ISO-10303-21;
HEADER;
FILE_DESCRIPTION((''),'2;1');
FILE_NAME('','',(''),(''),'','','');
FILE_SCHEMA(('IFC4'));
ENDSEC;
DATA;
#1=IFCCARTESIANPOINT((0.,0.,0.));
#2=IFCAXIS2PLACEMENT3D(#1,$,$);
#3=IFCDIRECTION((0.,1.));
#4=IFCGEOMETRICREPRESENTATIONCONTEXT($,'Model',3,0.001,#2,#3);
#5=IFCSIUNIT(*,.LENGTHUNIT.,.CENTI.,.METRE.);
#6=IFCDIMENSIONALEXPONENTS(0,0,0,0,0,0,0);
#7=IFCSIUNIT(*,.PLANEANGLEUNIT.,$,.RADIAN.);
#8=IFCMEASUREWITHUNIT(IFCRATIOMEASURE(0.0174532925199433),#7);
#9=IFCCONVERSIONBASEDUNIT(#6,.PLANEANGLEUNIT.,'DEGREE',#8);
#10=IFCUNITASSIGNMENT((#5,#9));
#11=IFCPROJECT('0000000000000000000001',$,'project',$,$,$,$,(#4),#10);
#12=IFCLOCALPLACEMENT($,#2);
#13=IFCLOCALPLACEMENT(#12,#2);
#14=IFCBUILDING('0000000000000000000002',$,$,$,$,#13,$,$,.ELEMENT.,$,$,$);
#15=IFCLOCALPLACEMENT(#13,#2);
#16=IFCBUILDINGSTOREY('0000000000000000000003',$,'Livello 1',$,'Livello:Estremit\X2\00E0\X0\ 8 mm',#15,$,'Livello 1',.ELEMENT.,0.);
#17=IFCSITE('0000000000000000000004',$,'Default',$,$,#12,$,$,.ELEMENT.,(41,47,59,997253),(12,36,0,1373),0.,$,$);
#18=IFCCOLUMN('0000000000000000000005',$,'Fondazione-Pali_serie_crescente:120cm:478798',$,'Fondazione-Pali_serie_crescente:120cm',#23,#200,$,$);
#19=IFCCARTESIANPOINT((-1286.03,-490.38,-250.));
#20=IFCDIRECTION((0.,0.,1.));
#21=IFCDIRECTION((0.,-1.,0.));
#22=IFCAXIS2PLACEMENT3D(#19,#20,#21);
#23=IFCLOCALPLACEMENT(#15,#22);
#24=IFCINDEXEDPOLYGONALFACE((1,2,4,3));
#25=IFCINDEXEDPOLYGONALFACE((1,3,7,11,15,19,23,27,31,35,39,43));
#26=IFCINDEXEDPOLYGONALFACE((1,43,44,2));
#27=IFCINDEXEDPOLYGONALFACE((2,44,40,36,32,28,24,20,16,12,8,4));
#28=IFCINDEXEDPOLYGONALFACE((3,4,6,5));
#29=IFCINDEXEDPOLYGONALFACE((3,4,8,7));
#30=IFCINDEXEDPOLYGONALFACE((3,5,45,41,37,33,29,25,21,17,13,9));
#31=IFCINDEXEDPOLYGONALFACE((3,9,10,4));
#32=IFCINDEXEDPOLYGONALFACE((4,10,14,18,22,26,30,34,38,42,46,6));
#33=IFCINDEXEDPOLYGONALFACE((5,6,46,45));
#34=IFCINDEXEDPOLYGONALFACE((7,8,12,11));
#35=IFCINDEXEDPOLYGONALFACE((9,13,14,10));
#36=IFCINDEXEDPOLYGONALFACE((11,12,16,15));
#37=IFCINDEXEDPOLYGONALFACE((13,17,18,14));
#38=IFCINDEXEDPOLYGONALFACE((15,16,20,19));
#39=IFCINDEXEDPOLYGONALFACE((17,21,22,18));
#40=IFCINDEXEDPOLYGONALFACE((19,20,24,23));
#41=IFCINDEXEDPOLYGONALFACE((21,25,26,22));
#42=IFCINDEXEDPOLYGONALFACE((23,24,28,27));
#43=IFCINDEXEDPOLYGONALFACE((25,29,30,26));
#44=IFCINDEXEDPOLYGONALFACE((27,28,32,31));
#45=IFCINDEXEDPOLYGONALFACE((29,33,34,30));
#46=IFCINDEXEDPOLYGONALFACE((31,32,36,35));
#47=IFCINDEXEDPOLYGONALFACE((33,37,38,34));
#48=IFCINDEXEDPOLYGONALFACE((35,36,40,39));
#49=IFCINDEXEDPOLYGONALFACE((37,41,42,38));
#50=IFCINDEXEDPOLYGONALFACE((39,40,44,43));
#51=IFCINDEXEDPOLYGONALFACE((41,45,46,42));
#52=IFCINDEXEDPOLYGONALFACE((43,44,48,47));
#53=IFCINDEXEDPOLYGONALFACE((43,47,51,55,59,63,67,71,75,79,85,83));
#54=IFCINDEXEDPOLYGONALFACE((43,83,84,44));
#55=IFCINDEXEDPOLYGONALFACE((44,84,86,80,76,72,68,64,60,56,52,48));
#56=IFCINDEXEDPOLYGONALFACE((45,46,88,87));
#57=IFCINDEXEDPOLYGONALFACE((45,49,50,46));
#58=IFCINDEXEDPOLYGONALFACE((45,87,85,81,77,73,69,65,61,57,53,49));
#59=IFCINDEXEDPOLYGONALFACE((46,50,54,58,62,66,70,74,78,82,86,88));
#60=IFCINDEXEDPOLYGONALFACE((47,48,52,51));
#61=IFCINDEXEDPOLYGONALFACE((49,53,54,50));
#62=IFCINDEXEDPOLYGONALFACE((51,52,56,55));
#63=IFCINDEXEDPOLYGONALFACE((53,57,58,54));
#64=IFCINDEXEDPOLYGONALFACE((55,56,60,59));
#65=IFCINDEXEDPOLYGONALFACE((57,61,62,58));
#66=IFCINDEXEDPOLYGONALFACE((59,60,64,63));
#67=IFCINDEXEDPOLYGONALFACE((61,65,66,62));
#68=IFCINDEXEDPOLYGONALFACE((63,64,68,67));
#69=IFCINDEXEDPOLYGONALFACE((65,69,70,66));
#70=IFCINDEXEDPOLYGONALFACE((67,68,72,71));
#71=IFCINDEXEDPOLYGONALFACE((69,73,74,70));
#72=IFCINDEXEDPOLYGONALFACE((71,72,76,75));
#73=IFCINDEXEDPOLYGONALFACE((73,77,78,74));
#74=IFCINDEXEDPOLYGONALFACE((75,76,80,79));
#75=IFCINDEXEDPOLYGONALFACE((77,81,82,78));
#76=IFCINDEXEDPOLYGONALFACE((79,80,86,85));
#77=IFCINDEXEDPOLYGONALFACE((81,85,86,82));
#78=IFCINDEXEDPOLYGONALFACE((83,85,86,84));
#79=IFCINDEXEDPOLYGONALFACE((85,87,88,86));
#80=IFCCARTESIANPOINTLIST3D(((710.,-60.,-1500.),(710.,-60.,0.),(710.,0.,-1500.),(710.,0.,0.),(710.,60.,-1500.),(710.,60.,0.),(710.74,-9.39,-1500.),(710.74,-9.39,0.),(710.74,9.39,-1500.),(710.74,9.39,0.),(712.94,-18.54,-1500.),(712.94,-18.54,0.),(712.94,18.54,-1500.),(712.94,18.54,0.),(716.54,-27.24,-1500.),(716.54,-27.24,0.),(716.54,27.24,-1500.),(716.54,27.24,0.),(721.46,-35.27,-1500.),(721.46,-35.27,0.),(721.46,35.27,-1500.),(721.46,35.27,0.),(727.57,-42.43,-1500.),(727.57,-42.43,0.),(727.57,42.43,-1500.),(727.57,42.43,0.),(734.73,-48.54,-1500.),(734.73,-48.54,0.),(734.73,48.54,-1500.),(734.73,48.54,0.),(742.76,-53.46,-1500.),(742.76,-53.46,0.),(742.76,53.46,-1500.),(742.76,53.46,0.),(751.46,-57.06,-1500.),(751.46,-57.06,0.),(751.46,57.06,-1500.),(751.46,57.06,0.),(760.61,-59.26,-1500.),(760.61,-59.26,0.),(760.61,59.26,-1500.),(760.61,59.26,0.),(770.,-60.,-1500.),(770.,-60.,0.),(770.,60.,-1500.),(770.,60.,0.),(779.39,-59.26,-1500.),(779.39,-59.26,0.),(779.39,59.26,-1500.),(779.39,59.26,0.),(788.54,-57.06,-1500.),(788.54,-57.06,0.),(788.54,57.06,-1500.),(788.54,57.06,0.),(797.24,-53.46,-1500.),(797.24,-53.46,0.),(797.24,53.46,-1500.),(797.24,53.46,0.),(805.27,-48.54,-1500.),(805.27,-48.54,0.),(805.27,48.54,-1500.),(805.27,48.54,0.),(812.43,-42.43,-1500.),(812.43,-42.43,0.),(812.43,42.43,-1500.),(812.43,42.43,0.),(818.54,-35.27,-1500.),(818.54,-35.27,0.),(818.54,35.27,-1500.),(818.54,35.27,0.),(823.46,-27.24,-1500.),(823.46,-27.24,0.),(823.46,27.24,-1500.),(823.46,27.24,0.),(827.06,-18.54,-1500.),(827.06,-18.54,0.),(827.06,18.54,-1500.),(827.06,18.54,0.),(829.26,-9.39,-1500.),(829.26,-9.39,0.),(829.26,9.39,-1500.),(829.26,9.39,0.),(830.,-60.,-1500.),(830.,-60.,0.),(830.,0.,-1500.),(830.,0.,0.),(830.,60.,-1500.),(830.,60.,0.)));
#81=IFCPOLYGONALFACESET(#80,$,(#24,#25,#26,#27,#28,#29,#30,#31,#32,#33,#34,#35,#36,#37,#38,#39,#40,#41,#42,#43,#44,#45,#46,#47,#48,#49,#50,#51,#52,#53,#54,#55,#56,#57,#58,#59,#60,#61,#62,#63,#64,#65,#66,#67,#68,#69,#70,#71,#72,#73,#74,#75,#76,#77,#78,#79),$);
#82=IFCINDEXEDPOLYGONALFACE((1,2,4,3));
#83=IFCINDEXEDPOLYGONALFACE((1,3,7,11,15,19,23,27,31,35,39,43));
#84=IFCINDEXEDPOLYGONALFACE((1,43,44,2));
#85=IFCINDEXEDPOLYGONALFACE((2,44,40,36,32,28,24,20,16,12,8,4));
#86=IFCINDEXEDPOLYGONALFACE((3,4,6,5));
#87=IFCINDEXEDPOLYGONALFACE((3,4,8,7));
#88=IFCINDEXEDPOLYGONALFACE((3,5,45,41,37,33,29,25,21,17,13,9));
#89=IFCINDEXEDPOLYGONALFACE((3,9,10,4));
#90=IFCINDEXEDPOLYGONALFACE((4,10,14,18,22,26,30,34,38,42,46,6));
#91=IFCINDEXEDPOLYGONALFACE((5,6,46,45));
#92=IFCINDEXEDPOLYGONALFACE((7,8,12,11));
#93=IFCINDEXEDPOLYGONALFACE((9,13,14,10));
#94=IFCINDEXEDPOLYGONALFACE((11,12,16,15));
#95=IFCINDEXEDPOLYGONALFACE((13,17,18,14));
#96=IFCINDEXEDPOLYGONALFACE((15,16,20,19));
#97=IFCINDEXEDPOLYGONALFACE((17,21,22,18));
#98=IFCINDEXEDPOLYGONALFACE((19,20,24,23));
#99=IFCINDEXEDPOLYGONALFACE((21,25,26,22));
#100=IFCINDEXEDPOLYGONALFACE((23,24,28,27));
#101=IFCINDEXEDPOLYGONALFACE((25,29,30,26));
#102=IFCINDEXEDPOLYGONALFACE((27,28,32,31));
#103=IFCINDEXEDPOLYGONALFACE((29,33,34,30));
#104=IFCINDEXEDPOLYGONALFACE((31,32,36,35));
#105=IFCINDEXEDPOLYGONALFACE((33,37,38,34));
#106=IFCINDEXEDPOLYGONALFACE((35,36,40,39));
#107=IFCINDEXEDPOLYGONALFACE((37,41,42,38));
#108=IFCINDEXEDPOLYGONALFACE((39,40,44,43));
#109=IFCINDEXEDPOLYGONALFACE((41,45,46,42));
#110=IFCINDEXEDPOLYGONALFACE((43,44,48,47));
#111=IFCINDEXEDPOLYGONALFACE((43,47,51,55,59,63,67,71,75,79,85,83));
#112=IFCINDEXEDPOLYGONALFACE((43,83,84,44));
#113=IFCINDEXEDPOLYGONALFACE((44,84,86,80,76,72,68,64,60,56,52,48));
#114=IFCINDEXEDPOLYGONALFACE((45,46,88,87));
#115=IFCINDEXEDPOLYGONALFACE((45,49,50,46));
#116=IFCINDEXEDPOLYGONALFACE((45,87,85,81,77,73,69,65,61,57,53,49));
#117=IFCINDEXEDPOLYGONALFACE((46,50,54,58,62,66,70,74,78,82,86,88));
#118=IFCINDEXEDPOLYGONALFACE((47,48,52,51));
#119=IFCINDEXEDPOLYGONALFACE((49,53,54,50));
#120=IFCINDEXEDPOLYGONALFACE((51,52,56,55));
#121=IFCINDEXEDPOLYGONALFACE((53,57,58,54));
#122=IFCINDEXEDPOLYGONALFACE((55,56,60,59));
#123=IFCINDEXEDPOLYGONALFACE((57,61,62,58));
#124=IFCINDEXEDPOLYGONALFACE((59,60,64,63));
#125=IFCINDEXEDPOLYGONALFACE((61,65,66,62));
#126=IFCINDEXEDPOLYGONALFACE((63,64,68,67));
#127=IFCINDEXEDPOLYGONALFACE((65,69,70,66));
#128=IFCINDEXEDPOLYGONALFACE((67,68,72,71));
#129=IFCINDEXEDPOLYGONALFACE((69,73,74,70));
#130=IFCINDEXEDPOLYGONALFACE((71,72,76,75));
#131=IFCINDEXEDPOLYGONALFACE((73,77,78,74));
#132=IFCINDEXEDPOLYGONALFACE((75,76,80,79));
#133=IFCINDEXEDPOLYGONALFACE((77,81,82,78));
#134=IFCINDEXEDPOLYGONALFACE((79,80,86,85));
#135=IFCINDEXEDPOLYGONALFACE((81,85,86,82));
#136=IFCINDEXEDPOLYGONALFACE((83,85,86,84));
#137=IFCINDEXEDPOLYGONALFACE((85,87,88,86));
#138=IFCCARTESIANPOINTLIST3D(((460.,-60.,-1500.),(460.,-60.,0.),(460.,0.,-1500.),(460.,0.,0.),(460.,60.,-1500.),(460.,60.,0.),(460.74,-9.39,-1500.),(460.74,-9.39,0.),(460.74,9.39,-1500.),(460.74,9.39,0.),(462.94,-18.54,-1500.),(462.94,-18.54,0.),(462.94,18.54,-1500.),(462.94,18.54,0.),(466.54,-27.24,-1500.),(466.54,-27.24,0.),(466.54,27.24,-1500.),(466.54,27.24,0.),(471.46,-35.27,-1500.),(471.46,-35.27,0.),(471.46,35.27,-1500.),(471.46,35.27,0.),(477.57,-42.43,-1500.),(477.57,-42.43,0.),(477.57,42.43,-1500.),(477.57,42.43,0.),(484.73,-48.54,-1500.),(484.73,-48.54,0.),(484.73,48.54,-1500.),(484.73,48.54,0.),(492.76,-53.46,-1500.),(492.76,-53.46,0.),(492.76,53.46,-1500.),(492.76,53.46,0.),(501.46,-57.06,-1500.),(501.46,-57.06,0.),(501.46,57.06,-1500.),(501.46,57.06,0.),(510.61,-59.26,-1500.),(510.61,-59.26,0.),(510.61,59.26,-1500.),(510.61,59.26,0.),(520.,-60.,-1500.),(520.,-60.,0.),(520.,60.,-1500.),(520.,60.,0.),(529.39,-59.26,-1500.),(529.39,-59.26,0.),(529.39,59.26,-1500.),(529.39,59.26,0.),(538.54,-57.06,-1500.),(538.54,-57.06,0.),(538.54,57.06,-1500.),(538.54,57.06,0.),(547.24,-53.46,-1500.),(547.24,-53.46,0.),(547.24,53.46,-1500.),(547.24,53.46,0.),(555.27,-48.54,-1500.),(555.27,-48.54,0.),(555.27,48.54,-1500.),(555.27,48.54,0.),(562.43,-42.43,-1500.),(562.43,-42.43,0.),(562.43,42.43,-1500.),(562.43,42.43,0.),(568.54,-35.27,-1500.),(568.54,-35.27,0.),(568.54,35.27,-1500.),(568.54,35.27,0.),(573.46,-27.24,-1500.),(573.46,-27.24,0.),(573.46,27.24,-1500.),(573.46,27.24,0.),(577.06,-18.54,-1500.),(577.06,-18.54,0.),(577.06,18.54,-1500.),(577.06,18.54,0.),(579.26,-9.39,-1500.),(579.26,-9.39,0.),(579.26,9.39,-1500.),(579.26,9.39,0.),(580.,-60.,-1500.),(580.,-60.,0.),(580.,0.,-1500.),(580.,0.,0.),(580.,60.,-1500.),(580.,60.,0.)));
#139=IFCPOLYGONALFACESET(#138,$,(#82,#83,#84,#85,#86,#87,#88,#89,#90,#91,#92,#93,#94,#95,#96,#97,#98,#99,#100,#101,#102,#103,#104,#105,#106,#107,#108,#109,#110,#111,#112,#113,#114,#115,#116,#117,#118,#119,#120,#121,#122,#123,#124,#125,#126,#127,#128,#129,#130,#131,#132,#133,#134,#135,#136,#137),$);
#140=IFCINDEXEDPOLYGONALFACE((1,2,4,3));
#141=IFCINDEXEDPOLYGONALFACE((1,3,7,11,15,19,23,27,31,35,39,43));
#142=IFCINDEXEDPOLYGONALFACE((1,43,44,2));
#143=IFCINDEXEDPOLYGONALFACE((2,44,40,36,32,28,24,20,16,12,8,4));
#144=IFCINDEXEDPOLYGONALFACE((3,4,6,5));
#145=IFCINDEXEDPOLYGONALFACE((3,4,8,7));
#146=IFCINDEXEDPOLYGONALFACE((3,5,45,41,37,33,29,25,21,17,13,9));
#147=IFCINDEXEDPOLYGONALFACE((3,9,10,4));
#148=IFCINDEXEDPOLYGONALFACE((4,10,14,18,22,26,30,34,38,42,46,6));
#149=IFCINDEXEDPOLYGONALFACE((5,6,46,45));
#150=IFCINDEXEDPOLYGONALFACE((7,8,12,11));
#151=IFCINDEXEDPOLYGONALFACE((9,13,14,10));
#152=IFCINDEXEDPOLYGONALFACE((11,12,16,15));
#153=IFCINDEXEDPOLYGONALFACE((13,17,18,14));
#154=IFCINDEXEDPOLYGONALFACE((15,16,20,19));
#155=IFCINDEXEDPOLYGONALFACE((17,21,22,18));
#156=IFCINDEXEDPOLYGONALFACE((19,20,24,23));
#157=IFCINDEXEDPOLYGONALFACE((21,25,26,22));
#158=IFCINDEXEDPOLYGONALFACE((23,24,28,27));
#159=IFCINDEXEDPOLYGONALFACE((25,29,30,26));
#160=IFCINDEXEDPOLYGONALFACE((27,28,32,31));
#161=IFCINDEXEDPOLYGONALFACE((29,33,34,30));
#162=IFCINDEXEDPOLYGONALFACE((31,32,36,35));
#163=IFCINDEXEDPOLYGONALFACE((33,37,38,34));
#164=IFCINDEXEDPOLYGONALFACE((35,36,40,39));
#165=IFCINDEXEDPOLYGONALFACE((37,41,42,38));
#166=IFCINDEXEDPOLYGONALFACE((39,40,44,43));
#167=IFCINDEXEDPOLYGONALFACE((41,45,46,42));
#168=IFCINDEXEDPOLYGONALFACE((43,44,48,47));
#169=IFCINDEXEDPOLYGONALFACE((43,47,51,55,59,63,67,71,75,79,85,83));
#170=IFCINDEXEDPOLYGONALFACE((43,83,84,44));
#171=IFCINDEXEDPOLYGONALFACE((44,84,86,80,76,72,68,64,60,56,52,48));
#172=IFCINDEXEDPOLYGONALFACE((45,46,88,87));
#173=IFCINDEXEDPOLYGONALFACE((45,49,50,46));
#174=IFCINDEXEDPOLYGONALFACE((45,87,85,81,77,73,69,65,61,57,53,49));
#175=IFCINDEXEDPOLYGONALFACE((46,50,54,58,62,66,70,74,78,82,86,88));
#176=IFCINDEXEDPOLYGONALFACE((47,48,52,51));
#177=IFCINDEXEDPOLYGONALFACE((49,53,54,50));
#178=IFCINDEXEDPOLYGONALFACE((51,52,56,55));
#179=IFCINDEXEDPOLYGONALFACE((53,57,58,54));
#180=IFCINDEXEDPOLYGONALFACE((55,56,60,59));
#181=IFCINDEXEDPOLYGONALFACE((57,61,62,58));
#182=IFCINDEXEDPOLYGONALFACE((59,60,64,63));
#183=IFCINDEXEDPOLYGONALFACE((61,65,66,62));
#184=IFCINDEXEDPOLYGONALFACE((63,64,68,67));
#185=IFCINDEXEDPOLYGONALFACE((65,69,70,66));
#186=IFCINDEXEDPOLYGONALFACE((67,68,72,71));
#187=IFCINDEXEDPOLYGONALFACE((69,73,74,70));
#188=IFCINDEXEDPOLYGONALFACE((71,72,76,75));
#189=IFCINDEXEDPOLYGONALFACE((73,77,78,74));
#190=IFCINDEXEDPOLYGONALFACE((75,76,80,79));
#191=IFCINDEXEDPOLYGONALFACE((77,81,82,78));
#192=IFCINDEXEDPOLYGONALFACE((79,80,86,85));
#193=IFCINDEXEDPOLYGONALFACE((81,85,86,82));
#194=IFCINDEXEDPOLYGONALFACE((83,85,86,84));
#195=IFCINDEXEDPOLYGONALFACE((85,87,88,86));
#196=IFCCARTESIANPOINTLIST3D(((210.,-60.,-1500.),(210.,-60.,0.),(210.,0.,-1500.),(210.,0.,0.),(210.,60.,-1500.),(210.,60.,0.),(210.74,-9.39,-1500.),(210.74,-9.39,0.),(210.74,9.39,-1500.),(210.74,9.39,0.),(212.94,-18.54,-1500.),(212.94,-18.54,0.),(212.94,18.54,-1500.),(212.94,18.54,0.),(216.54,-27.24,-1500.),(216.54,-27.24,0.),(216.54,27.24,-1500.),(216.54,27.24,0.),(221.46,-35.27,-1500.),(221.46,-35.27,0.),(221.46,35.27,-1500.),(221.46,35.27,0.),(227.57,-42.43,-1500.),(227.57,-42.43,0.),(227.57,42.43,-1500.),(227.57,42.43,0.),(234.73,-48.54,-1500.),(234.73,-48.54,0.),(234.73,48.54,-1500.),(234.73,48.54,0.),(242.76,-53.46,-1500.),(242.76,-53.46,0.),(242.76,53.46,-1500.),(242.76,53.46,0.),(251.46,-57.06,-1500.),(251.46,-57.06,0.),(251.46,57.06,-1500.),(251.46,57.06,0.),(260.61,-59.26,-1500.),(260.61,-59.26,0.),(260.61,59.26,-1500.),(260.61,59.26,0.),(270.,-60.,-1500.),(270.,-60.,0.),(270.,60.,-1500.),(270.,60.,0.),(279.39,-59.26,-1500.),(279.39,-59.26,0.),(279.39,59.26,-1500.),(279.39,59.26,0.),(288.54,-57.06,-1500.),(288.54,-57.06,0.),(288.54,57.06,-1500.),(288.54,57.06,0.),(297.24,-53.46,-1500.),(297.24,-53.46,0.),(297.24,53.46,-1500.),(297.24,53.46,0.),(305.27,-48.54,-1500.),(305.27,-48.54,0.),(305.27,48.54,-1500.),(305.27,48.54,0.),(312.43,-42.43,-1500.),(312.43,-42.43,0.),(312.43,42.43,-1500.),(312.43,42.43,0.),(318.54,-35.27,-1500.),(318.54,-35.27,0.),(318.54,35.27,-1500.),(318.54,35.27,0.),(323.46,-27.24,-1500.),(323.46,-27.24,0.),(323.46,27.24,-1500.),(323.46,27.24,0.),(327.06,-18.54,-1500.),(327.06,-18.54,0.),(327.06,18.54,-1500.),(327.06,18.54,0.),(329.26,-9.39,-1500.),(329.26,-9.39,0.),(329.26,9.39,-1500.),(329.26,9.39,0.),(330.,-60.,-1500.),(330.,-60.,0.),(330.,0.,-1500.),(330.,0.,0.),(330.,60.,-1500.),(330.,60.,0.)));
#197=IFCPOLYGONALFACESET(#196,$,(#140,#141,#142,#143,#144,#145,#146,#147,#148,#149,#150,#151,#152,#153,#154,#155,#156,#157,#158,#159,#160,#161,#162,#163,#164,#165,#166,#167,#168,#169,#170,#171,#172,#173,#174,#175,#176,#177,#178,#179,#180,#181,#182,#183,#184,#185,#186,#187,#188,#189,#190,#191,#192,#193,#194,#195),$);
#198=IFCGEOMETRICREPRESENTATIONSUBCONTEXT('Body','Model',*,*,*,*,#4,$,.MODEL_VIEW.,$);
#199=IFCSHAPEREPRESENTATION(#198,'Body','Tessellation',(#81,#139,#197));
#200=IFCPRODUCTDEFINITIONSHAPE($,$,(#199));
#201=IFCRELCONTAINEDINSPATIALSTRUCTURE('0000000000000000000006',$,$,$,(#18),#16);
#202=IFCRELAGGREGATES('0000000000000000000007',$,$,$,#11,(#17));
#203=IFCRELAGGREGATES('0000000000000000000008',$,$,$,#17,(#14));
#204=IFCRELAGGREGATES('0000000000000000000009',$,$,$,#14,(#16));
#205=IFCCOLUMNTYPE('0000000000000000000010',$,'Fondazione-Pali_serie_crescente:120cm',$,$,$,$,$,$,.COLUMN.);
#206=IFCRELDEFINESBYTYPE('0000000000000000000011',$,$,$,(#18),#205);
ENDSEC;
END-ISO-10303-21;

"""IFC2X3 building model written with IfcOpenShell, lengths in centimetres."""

from ifc_helpers import new_model, entity, si_unit, converted_unit, direction, frame, frame_2d, origin, origin_2d_with_axis, place, context, subcontext, project, spatial, rectangle, circle, extrude, boolean, source, transform, mapped, type_object, type_shapes, element, save


model = new_model("IFC2X3")

# Units and contexts
model_context = context("Model", 3, precision=0.001, world=origin(), true_north=direction((0.0, 1.0)))
body_context = subcontext(model_context, "Body", "Model", "MODEL_VIEW")
ifc_project = project(units=[si_unit("LENGTHUNIT", "METRE", prefix="CENTI"), converted_unit("PLANEANGLEUNIT", "DEGREE", entity("IfcRatioMeasure", 0.0174532925199433), si_unit("PLANEANGLEUNIT", "RADIAN"), dimensions=[0, 0, 0, 0, 0, 0, 0])], contexts=[model_context])

# Site, building, storey
site_placement = place(None, origin())
site = spatial("IfcSite", under=ifc_project, at=site_placement, Name="Default", CompositionType="ELEMENT", RefLatitude=(41, 47, 59, 997253), RefLongitude=(12, 36, 0, 1373), RefElevation=0.0)
building_placement = place(site_placement, origin())
building = spatial("IfcBuilding", under=site, at=building_placement, CompositionType="ELEMENT")
storey_placement = place(building_placement, origin())
storey = spatial("IfcBuildingStorey", under=building, at=storey_placement, Name="Livello 1", ObjectType="Livello:Estremità 8 mm", LongName="Livello 1", CompositionType="ELEMENT", Elevation=0.0)

# Column
column_type_1 = type_object("IfcColumnType", Name="Fondazione-Pali_serie_crescente:120cm", PredefinedType="COLUMN")
shared_shape_1 = source(origin(), body_context, "Body", "SweptSolid", [
    boolean("DIFFERENCE", extrude(rectangle(XDim=1500.0, YDim=120.0, at=origin_2d_with_axis()), frame((710.0, 0.0, -750.0), z_axis=(1.0, 0.0, 0.0), x_axis=(0.0, 0.0, -1.0)), (0.0, 0.0, 1.0), 120.0), extrude(circle(Radius=60.0, at=frame_2d((0.0, 0.0), x_axis=(1.0, 0.0))), frame((770.0, 0.0, 0.0)), (0.0, 0.0, -1.0), 1500.0)),
    boolean("DIFFERENCE", extrude(rectangle(XDim=1500.0, YDim=120.0, at=origin_2d_with_axis()), frame((460.0, 0.0, -750.0), z_axis=(1.0, 0.0, 0.0), x_axis=(0.0, 0.0, -1.0)), (0.0, 0.0, 1.0), 120.0), extrude(circle(Radius=60.0, at=frame_2d((0.0, 0.0), x_axis=(1.0, 0.0))), frame((520.0, 0.0, 0.0)), (0.0, 0.0, -1.0), 1500.0)),
    boolean("DIFFERENCE", extrude(rectangle(XDim=1500.0, YDim=120.0, at=origin_2d_with_axis()), frame((210.0, 0.0, -750.0), z_axis=(1.0, 0.0, 0.0), x_axis=(0.0, 0.0, -1.0)), (0.0, 0.0, 1.0), 120.0), extrude(circle(Radius=60.0, at=frame_2d((0.0, 0.0), x_axis=(1.0, 0.0))), frame((270.0, 0.0, 0.0)), (0.0, 0.0, -1.0), 1500.0)),
])
type_shapes(column_type_1, [shared_shape_1])
for number, where, z_axis, x_axis, name in (
    (1, (-1286.03, -490.38, -250.0), (0.0, 0.0, 1.0), (0.0, -1.0, 0.0), "Fondazione-Pali_serie_crescente:120cm:478798"),
):
    element("IfcColumn", number, at=place(storey_placement, frame(where, z_axis=z_axis, x_axis=x_axis)), inside=storey, type_object=column_type_1, Name=name, ObjectType="Fondazione-Pali_serie_crescente:120cm", context=body_context, shape_type="MappedRepresentation", body=[
        mapped(shared_shape_1, transform((0.0, 0.0, 0.0), scale=1.0)),
    ])

save(model, "model.ifc")
